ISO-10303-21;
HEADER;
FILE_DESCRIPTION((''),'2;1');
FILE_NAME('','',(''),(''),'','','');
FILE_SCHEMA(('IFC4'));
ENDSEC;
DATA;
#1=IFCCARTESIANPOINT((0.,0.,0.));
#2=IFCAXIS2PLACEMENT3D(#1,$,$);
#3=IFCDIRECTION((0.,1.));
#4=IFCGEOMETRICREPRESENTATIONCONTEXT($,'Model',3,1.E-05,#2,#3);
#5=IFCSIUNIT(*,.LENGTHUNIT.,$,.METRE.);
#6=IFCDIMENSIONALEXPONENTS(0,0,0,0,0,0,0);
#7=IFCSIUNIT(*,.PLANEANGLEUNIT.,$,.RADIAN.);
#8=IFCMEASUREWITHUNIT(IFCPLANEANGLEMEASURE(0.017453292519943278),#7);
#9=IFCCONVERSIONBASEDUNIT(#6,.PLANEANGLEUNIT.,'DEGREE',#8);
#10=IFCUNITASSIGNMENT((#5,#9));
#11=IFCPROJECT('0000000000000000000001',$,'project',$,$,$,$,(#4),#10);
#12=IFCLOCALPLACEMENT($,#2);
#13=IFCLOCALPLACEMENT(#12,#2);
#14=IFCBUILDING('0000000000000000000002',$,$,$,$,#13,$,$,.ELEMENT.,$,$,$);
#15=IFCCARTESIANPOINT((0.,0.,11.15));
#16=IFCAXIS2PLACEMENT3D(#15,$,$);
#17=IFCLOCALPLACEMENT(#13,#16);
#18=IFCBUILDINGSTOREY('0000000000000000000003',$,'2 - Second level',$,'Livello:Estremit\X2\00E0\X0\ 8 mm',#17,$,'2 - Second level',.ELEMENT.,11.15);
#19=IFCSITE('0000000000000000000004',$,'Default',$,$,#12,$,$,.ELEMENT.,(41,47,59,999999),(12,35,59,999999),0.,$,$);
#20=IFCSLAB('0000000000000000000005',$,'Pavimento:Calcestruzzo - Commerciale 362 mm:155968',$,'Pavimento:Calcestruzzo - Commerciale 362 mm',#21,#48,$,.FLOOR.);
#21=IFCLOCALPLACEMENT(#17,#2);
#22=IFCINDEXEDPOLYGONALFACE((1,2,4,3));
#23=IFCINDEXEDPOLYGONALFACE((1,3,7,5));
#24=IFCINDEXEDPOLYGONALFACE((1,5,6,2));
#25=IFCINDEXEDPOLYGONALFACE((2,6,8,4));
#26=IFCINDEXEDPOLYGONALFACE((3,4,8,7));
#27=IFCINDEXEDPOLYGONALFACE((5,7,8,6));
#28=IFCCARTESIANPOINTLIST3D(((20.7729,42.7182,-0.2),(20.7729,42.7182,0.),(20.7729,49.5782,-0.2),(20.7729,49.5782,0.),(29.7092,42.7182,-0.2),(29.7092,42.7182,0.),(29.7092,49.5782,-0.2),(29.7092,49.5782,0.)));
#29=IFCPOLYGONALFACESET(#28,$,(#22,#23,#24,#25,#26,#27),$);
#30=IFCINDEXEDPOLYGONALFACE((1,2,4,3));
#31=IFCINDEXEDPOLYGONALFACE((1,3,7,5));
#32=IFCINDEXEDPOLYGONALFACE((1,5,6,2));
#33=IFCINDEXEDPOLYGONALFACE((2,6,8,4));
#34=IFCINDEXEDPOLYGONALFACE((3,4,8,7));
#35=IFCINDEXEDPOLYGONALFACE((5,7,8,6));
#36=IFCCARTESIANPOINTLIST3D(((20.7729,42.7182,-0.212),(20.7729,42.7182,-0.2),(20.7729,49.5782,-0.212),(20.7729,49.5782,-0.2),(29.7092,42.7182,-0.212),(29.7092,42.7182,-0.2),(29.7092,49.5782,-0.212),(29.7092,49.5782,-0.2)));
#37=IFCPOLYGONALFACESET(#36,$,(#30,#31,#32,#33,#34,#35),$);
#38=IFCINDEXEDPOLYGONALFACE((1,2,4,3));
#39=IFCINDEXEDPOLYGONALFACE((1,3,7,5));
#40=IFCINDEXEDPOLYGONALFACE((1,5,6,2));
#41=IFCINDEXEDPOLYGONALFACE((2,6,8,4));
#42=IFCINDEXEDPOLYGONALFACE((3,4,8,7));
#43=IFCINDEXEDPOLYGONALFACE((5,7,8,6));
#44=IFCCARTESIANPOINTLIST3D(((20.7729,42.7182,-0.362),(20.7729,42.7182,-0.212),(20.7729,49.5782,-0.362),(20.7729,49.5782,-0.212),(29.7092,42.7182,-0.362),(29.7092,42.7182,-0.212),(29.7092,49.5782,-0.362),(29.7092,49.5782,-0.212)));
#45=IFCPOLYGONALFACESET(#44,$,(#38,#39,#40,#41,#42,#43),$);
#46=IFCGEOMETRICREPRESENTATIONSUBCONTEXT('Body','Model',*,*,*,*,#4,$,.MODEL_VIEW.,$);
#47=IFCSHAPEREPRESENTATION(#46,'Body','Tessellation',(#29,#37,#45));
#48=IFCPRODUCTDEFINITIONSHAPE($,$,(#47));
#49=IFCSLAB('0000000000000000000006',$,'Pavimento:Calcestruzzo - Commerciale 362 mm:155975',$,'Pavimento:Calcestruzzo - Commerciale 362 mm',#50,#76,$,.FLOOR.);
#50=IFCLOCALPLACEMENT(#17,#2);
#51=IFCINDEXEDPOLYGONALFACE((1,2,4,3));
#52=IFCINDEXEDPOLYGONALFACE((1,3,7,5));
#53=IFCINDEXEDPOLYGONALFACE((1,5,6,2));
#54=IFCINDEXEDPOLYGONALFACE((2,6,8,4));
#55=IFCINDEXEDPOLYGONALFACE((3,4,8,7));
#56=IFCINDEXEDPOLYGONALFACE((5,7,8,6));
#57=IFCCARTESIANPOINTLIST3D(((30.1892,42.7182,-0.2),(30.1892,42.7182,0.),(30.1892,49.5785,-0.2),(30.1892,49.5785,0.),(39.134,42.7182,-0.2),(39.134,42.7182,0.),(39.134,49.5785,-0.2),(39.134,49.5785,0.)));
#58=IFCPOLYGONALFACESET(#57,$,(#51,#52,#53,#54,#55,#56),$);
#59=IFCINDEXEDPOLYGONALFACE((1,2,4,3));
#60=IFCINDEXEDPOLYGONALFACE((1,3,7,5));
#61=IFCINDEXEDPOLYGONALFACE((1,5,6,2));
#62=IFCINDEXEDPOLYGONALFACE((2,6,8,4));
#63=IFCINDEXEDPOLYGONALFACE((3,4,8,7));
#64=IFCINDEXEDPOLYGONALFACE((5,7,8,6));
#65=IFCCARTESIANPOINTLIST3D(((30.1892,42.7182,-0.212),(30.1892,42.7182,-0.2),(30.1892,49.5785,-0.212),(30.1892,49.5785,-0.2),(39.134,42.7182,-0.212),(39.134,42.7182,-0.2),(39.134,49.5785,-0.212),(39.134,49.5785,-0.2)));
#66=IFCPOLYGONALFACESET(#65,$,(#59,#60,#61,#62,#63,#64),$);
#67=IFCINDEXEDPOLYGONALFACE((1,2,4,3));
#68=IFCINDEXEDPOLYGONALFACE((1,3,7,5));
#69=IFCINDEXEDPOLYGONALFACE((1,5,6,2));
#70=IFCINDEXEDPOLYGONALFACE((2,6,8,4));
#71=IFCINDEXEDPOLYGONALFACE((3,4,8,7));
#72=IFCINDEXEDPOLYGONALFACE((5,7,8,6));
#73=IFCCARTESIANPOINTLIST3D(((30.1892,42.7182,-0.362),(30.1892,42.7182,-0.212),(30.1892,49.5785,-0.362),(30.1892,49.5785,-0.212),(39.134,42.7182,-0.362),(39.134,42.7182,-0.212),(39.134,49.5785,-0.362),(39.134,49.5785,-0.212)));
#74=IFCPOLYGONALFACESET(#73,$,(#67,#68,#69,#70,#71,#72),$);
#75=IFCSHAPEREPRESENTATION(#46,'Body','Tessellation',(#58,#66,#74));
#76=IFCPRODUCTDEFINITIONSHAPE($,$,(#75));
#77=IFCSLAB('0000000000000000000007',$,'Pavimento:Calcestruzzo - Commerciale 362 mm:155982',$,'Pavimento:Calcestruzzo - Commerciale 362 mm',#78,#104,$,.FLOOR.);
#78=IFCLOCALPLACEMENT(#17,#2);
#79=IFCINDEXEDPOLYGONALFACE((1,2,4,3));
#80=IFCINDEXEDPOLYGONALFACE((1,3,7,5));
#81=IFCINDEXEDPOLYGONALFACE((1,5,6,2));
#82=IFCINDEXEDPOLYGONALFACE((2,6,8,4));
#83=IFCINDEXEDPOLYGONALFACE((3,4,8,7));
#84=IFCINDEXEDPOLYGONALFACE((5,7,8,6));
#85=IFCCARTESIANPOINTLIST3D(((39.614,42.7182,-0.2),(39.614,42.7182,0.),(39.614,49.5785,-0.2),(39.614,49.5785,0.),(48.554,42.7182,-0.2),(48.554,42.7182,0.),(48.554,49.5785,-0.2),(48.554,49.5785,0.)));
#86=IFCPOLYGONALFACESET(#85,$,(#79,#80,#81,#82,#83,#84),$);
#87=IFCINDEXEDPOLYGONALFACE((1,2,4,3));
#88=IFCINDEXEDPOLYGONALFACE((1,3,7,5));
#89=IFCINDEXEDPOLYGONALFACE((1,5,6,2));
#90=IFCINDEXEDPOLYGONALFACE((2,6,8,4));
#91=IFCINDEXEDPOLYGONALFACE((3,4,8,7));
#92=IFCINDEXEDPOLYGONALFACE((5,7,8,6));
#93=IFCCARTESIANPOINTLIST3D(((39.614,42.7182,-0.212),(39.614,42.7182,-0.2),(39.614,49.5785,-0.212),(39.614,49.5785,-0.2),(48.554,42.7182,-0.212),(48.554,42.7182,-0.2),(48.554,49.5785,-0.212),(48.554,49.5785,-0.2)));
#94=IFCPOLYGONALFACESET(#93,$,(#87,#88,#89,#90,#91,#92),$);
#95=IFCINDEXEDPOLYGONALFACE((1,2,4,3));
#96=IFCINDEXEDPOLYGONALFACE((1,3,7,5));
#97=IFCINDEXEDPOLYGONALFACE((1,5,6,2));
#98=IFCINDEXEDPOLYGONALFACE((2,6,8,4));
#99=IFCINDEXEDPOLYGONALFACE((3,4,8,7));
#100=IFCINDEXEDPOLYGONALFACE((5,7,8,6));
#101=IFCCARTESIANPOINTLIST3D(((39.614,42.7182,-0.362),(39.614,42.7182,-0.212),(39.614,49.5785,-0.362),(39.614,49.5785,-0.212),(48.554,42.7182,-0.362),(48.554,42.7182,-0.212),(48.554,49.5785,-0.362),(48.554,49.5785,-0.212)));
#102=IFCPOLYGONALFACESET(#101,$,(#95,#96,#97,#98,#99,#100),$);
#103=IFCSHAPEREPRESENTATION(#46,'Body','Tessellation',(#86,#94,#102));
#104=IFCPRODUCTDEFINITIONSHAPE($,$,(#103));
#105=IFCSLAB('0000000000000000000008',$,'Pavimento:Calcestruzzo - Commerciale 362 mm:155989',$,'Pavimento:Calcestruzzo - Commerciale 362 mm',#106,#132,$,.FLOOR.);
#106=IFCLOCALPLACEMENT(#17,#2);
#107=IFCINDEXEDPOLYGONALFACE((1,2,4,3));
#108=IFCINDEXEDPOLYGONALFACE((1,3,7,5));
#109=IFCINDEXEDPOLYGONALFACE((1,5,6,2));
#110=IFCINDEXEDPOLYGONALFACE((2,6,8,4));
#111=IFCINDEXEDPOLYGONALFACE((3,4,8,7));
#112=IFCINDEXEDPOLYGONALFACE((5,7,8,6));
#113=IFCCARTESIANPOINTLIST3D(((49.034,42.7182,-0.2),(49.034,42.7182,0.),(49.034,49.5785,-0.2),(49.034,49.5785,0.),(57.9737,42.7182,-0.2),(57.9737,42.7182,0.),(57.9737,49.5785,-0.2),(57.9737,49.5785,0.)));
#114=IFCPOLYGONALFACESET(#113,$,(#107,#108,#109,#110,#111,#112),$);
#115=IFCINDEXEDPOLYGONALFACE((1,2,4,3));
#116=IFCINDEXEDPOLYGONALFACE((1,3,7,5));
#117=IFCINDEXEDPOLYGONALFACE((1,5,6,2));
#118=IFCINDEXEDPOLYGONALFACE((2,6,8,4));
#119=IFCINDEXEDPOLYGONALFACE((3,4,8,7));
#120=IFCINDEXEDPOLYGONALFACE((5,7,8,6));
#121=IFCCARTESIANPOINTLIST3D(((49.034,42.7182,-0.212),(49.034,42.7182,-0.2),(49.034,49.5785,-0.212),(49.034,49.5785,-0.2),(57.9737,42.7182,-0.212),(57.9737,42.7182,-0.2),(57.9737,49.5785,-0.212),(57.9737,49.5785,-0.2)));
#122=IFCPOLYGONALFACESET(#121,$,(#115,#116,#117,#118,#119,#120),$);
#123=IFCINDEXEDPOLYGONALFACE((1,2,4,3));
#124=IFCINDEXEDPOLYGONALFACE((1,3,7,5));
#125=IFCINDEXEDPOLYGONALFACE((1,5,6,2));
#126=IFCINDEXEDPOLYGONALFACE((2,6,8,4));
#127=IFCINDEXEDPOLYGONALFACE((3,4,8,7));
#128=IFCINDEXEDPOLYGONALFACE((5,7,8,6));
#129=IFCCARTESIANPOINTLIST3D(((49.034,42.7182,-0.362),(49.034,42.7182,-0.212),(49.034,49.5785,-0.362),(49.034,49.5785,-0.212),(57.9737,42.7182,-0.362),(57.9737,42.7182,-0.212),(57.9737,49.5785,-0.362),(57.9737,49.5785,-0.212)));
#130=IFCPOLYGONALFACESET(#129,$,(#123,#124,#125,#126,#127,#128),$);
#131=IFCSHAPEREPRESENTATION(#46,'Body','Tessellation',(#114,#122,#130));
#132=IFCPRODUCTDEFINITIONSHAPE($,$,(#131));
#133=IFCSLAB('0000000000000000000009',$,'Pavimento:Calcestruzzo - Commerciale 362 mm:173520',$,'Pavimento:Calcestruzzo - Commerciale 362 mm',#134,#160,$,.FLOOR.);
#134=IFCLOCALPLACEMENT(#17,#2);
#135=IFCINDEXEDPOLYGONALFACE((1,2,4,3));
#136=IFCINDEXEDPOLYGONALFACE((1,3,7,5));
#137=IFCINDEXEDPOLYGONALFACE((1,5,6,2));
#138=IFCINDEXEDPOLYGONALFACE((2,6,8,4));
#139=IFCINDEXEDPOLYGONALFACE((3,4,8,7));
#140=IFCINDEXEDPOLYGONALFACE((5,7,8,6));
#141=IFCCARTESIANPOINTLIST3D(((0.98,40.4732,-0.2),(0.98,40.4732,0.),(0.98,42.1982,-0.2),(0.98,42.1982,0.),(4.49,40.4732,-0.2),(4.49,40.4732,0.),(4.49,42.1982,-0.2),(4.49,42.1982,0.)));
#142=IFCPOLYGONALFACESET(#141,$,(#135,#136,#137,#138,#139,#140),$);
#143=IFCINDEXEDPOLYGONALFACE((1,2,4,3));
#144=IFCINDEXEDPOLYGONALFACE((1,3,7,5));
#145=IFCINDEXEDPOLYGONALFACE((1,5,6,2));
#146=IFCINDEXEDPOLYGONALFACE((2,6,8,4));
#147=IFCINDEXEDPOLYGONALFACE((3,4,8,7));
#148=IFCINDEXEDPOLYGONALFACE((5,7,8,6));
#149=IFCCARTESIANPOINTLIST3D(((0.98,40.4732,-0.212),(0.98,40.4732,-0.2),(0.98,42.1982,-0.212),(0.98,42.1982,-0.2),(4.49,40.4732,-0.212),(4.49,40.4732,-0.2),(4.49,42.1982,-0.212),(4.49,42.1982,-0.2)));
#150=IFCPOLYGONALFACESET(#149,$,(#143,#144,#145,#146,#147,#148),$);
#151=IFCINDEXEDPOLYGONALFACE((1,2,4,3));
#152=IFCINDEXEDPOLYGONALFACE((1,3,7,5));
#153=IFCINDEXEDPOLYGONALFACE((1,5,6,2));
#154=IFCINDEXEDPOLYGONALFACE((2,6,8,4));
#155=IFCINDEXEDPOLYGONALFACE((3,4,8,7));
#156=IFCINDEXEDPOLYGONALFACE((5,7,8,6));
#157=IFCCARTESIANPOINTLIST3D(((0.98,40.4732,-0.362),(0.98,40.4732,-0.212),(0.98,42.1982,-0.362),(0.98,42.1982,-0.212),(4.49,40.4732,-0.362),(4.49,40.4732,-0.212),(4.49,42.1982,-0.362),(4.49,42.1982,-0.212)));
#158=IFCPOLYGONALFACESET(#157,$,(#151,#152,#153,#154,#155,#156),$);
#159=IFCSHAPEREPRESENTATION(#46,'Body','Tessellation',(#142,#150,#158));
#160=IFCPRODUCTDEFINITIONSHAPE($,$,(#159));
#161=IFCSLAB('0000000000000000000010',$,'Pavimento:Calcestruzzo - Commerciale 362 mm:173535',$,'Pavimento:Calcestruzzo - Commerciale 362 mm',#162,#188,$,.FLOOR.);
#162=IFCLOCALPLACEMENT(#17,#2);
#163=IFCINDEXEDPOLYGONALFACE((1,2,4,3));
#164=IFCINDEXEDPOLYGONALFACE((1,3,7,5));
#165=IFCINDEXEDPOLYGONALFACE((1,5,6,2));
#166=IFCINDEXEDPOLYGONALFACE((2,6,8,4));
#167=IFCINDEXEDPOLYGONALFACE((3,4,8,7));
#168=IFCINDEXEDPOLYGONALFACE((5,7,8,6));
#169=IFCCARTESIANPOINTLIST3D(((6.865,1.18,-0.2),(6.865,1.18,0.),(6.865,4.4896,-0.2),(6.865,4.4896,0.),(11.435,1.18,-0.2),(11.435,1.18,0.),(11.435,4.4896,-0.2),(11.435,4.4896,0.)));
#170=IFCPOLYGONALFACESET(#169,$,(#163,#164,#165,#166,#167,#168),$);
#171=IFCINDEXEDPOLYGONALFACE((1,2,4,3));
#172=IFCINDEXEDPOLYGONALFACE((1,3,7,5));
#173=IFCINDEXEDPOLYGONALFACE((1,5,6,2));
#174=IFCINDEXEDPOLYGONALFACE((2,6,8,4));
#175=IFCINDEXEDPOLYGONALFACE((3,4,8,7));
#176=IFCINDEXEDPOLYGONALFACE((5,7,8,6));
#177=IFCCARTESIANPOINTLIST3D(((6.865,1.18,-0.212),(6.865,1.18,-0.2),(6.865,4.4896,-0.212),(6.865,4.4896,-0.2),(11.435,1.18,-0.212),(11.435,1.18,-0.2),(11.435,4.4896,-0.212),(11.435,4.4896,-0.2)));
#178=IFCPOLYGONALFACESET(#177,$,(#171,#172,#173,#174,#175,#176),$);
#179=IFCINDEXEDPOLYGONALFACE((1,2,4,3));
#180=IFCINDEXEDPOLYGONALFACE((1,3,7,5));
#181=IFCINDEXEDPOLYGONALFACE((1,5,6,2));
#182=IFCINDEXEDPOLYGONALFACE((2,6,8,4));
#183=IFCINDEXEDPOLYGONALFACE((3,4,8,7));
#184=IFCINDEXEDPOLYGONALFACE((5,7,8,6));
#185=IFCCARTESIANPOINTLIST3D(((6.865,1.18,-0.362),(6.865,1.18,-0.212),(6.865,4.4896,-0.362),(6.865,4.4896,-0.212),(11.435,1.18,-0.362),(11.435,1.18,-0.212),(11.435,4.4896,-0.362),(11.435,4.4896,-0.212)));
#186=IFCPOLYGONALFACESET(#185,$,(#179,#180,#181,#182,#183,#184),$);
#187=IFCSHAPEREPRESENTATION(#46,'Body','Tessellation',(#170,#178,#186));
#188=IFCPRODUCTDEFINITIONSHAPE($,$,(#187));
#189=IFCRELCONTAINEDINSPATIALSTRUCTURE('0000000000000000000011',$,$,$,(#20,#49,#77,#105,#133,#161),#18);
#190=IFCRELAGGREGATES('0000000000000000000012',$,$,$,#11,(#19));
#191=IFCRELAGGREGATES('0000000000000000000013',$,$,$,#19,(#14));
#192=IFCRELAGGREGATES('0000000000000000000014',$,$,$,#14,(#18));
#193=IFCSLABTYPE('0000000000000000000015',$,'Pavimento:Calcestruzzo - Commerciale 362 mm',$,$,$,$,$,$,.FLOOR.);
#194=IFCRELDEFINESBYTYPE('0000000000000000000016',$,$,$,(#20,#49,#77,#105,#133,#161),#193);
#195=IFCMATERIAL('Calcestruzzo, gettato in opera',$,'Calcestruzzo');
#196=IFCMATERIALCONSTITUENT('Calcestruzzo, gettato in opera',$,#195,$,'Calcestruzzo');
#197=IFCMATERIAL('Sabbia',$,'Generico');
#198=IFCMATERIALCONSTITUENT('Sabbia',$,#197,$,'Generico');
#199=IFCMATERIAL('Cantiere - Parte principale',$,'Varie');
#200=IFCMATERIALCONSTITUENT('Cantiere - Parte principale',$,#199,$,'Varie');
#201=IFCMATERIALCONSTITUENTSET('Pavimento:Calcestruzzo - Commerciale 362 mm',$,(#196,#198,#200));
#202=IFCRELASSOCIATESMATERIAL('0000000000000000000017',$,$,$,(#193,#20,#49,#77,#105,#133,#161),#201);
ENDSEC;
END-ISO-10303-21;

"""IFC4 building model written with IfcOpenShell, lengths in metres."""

from ifc_helpers import new_model, entity, si_unit, converted_unit, direction, frame, origin, place, context, subcontext, project, spatial, indexed_curve, outline, extrude, material, constituent, constituent_set, type_object, element, save


model = new_model("IFC4")

# Units and contexts
model_context = context("Model", 3, precision=1e-05, world=origin(), true_north=direction((0.0, 1.0)))
body_context = subcontext(model_context, "Body", "Model", "MODEL_VIEW")
ifc_project = project(units=[si_unit("LENGTHUNIT", "METRE"), converted_unit("PLANEANGLEUNIT", "DEGREE", entity("IfcPlaneAngleMeasure", 0.017453292519943278), si_unit("PLANEANGLEUNIT", "RADIAN"), dimensions=[0, 0, 0, 0, 0, 0, 0])], contexts=[model_context])

# Site, building, storey
site_placement = place(None, origin())
site = spatial("IfcSite", under=ifc_project, at=site_placement, Name="Default", CompositionType="ELEMENT", RefLatitude=(41, 47, 59, 999999), RefLongitude=(12, 35, 59, 999999), RefElevation=0.0)
building_placement = place(site_placement, origin())
building = spatial("IfcBuilding", under=site, at=building_placement, CompositionType="ELEMENT")
storey_placement = place(building_placement, frame((0.0, 0.0, 11.15)))
storey = spatial("IfcBuildingStorey", under=building, at=storey_placement, Name="2 - Second level", ObjectType="Livello:Estremità 8 mm", LongName="2 - Second level", CompositionType="ELEMENT", Elevation=11.15)

# Slabs
ifc_material_1 = material(Name="Calcestruzzo, gettato in opera", Category="Calcestruzzo")
ifc_constituent_1 = constituent(ifc_material_1, Name="Calcestruzzo, gettato in opera", Category="Calcestruzzo")
ifc_material_2 = material(Name="Sabbia", Category="Generico")
ifc_constituent_2 = constituent(ifc_material_2, Name="Sabbia", Category="Generico")
ifc_material_3 = material(Name="Cantiere - Parte principale", Category="Varie")
ifc_constituent_3 = constituent(ifc_material_3, Name="Cantiere - Parte principale", Category="Varie")
ifc_constituent_set = constituent_set(constituents=[ifc_constituent_1, ifc_constituent_2, ifc_constituent_3], Name="Pavimento:Calcestruzzo - Commerciale 362 mm")
slab_type = type_object("IfcSlabType", Name="Pavimento:Calcestruzzo - Commerciale 362 mm", PredefinedType="FLOOR", material=ifc_constituent_set)
slab_1_placement = place(storey_placement, origin())
element("IfcSlab", 1, at=slab_1_placement, inside=storey, type_object=slab_type, material=ifc_constituent_set, Name="Pavimento:Calcestruzzo - Commerciale 362 mm:155968", ObjectType="Pavimento:Calcestruzzo - Commerciale 362 mm", PredefinedType="FLOOR", context=body_context, shape_type="SweptSolid", body=[
    extrude(outline(indexed_curve([(-3.43, -4.4681), (3.43, -4.4681), (3.43, 4.4681), (-3.43, 4.4681), (-3.43, -4.4681)], self_intersect=False)), frame((25.2411, 46.1482, -0.2), z_axis=(0.0, 0.0, 1.0), x_axis=(0.0, -1.0, 0.0)), (0.0, 0.0, 1.0), 0.2),
    extrude(outline(indexed_curve([(-3.43, -4.4681), (3.43, -4.4681), (3.43, 4.4681), (-3.43, 4.4681), (-3.43, -4.4681)], self_intersect=False)), frame((25.2411, 46.1482, -0.212), z_axis=(0.0, 0.0, 1.0), x_axis=(0.0, -1.0, 0.0)), (0.0, 0.0, 1.0), 0.012),
    extrude(outline(indexed_curve([(-3.43, -4.4681), (3.43, -4.4681), (3.43, 4.4681), (-3.43, 4.4681), (-3.43, -4.4681)], self_intersect=False)), frame((25.2411, 46.1482, -0.362), z_axis=(0.0, 0.0, 1.0), x_axis=(0.0, -1.0, 0.0)), (0.0, 0.0, 1.0), 0.15),
])
slab_2_placement = place(storey_placement, origin())
element("IfcSlab", 2, at=slab_2_placement, inside=storey, type_object=slab_type, material=ifc_constituent_set, Name="Pavimento:Calcestruzzo - Commerciale 362 mm:155975", ObjectType="Pavimento:Calcestruzzo - Commerciale 362 mm", PredefinedType="FLOOR", context=body_context, shape_type="SweptSolid", body=[
    extrude(outline(indexed_curve([(-3.4302, -4.4724), (3.4302, -4.4724), (3.4302, 4.4724), (-3.4302, 4.4724), (-3.4302, -4.4724)], self_intersect=False)), frame((34.6616, 46.1483, -0.2), z_axis=(0.0, 0.0, 1.0), x_axis=(0.0, -1.0, 0.0)), (0.0, 0.0, 1.0), 0.2),
    extrude(outline(indexed_curve([(-3.4302, -4.4724), (3.4302, -4.4724), (3.4302, 4.4724), (-3.4302, 4.4724), (-3.4302, -4.4724)], self_intersect=False)), frame((34.6616, 46.1483, -0.212), z_axis=(0.0, 0.0, 1.0), x_axis=(0.0, -1.0, 0.0)), (0.0, 0.0, 1.0), 0.012),
    extrude(outline(indexed_curve([(-3.4302, -4.4724), (3.4302, -4.4724), (3.4302, 4.4724), (-3.4302, 4.4724), (-3.4302, -4.4724)], self_intersect=False)), frame((34.6616, 46.1483, -0.362), z_axis=(0.0, 0.0, 1.0), x_axis=(0.0, -1.0, 0.0)), (0.0, 0.0, 1.0), 0.15),
])
slab_3_placement = place(storey_placement, origin())
element("IfcSlab", 3, at=slab_3_placement, inside=storey, type_object=slab_type, material=ifc_constituent_set, Name="Pavimento:Calcestruzzo - Commerciale 362 mm:155982", ObjectType="Pavimento:Calcestruzzo - Commerciale 362 mm", PredefinedType="FLOOR", context=body_context, shape_type="SweptSolid", body=[
    extrude(outline(indexed_curve([(-3.4302, -4.47), (3.4302, -4.47), (3.4302, 4.47), (-3.4302, 4.47), (-3.4302, -4.47)], self_intersect=False)), frame((44.084, 46.1483, -0.2), z_axis=(0.0, 0.0, 1.0), x_axis=(0.0, -1.0, 0.0)), (0.0, 0.0, 1.0), 0.2),
    extrude(outline(indexed_curve([(-3.4302, -4.47), (3.4302, -4.47), (3.4302, 4.47), (-3.4302, 4.47), (-3.4302, -4.47)], self_intersect=False)), frame((44.084, 46.1483, -0.212), z_axis=(0.0, 0.0, 1.0), x_axis=(0.0, -1.0, 0.0)), (0.0, 0.0, 1.0), 0.012),
    extrude(outline(indexed_curve([(-3.4302, -4.47), (3.4302, -4.47), (3.4302, 4.47), (-3.4302, 4.47), (-3.4302, -4.47)], self_intersect=False)), frame((44.084, 46.1483, -0.362), z_axis=(0.0, 0.0, 1.0), x_axis=(0.0, -1.0, 0.0)), (0.0, 0.0, 1.0), 0.15),
])
slab_4_placement = place(storey_placement, origin())
element("IfcSlab", 4, at=slab_4_placement, inside=storey, type_object=slab_type, material=ifc_constituent_set, Name="Pavimento:Calcestruzzo - Commerciale 362 mm:155989", ObjectType="Pavimento:Calcestruzzo - Commerciale 362 mm", PredefinedType="FLOOR", context=body_context, shape_type="SweptSolid", body=[
    extrude(outline(indexed_curve([(-3.4302, -4.4698), (3.4302, -4.4698), (3.4302, 4.4698), (-3.4302, 4.4698), (-3.4302, -4.4698)], self_intersect=False)), frame((53.5038, 46.1483, -0.2), z_axis=(0.0, 0.0, 1.0), x_axis=(0.0, -1.0, 0.0)), (0.0, 0.0, 1.0), 0.2),
    extrude(outline(indexed_curve([(-3.4302, -4.4698), (3.4302, -4.4698), (3.4302, 4.4698), (-3.4302, 4.4698), (-3.4302, -4.4698)], self_intersect=False)), frame((53.5038, 46.1483, -0.212), z_axis=(0.0, 0.0, 1.0), x_axis=(0.0, -1.0, 0.0)), (0.0, 0.0, 1.0), 0.012),
    extrude(outline(indexed_curve([(-3.4302, -4.4698), (3.4302, -4.4698), (3.4302, 4.4698), (-3.4302, 4.4698), (-3.4302, -4.4698)], self_intersect=False)), frame((53.5038, 46.1483, -0.362), z_axis=(0.0, 0.0, 1.0), x_axis=(0.0, -1.0, 0.0)), (0.0, 0.0, 1.0), 0.15),
])
slab_5_placement = place(storey_placement, origin())
element("IfcSlab", 5, at=slab_5_placement, inside=storey, type_object=slab_type, material=ifc_constituent_set, Name="Pavimento:Calcestruzzo - Commerciale 362 mm:173520", ObjectType="Pavimento:Calcestruzzo - Commerciale 362 mm", PredefinedType="FLOOR", context=body_context, shape_type="SweptSolid", body=[
    extrude(outline(indexed_curve([(-1.755, -0.8625), (1.755, -0.8625), (1.755, 0.8625), (-1.755, 0.8625), (-1.755, -0.8625)], self_intersect=False)), frame((2.735, 41.3357, -0.2)), (0.0, 0.0, 1.0), 0.2),
    extrude(outline(indexed_curve([(-1.755, -0.8625), (1.755, -0.8625), (1.755, 0.8625), (-1.755, 0.8625), (-1.755, -0.8625)], self_intersect=False)), frame((2.735, 41.3357, -0.212)), (0.0, 0.0, 1.0), 0.012),
    extrude(outline(indexed_curve([(-1.755, -0.8625), (1.755, -0.8625), (1.755, 0.8625), (-1.755, 0.8625), (-1.755, -0.8625)], self_intersect=False)), frame((2.735, 41.3357, -0.362)), (0.0, 0.0, 1.0), 0.15),
])
slab_6_placement = place(storey_placement, origin())
element("IfcSlab", 6, at=slab_6_placement, inside=storey, type_object=slab_type, material=ifc_constituent_set, Name="Pavimento:Calcestruzzo - Commerciale 362 mm:173535", ObjectType="Pavimento:Calcestruzzo - Commerciale 362 mm", PredefinedType="FLOOR", context=body_context, shape_type="SweptSolid", body=[
    extrude(outline(indexed_curve([(-1.6548, -2.285), (1.6548, -2.285), (1.6548, 2.285), (-1.6548, 2.285), (-1.6548, -2.285)], self_intersect=False)), frame((9.15, 2.8348, -0.2), z_axis=(0.0, 0.0, 1.0), x_axis=(0.0, 1.0, 0.0)), (0.0, 0.0, 1.0), 0.2),
    extrude(outline(indexed_curve([(-1.6548, -2.285), (1.6548, -2.285), (1.6548, 2.285), (-1.6548, 2.285), (-1.6548, -2.285)], self_intersect=False)), frame((9.15, 2.8348, -0.212), z_axis=(0.0, 0.0, 1.0), x_axis=(0.0, 1.0, 0.0)), (0.0, 0.0, 1.0), 0.012),
    extrude(outline(indexed_curve([(-1.6548, -2.285), (1.6548, -2.285), (1.6548, 2.285), (-1.6548, 2.285), (-1.6548, -2.285)], self_intersect=False)), frame((9.15, 2.8348, -0.362), z_axis=(0.0, 0.0, 1.0), x_axis=(0.0, 1.0, 0.0)), (0.0, 0.0, 1.0), 0.15),
])

save(model, "model.ifc")
